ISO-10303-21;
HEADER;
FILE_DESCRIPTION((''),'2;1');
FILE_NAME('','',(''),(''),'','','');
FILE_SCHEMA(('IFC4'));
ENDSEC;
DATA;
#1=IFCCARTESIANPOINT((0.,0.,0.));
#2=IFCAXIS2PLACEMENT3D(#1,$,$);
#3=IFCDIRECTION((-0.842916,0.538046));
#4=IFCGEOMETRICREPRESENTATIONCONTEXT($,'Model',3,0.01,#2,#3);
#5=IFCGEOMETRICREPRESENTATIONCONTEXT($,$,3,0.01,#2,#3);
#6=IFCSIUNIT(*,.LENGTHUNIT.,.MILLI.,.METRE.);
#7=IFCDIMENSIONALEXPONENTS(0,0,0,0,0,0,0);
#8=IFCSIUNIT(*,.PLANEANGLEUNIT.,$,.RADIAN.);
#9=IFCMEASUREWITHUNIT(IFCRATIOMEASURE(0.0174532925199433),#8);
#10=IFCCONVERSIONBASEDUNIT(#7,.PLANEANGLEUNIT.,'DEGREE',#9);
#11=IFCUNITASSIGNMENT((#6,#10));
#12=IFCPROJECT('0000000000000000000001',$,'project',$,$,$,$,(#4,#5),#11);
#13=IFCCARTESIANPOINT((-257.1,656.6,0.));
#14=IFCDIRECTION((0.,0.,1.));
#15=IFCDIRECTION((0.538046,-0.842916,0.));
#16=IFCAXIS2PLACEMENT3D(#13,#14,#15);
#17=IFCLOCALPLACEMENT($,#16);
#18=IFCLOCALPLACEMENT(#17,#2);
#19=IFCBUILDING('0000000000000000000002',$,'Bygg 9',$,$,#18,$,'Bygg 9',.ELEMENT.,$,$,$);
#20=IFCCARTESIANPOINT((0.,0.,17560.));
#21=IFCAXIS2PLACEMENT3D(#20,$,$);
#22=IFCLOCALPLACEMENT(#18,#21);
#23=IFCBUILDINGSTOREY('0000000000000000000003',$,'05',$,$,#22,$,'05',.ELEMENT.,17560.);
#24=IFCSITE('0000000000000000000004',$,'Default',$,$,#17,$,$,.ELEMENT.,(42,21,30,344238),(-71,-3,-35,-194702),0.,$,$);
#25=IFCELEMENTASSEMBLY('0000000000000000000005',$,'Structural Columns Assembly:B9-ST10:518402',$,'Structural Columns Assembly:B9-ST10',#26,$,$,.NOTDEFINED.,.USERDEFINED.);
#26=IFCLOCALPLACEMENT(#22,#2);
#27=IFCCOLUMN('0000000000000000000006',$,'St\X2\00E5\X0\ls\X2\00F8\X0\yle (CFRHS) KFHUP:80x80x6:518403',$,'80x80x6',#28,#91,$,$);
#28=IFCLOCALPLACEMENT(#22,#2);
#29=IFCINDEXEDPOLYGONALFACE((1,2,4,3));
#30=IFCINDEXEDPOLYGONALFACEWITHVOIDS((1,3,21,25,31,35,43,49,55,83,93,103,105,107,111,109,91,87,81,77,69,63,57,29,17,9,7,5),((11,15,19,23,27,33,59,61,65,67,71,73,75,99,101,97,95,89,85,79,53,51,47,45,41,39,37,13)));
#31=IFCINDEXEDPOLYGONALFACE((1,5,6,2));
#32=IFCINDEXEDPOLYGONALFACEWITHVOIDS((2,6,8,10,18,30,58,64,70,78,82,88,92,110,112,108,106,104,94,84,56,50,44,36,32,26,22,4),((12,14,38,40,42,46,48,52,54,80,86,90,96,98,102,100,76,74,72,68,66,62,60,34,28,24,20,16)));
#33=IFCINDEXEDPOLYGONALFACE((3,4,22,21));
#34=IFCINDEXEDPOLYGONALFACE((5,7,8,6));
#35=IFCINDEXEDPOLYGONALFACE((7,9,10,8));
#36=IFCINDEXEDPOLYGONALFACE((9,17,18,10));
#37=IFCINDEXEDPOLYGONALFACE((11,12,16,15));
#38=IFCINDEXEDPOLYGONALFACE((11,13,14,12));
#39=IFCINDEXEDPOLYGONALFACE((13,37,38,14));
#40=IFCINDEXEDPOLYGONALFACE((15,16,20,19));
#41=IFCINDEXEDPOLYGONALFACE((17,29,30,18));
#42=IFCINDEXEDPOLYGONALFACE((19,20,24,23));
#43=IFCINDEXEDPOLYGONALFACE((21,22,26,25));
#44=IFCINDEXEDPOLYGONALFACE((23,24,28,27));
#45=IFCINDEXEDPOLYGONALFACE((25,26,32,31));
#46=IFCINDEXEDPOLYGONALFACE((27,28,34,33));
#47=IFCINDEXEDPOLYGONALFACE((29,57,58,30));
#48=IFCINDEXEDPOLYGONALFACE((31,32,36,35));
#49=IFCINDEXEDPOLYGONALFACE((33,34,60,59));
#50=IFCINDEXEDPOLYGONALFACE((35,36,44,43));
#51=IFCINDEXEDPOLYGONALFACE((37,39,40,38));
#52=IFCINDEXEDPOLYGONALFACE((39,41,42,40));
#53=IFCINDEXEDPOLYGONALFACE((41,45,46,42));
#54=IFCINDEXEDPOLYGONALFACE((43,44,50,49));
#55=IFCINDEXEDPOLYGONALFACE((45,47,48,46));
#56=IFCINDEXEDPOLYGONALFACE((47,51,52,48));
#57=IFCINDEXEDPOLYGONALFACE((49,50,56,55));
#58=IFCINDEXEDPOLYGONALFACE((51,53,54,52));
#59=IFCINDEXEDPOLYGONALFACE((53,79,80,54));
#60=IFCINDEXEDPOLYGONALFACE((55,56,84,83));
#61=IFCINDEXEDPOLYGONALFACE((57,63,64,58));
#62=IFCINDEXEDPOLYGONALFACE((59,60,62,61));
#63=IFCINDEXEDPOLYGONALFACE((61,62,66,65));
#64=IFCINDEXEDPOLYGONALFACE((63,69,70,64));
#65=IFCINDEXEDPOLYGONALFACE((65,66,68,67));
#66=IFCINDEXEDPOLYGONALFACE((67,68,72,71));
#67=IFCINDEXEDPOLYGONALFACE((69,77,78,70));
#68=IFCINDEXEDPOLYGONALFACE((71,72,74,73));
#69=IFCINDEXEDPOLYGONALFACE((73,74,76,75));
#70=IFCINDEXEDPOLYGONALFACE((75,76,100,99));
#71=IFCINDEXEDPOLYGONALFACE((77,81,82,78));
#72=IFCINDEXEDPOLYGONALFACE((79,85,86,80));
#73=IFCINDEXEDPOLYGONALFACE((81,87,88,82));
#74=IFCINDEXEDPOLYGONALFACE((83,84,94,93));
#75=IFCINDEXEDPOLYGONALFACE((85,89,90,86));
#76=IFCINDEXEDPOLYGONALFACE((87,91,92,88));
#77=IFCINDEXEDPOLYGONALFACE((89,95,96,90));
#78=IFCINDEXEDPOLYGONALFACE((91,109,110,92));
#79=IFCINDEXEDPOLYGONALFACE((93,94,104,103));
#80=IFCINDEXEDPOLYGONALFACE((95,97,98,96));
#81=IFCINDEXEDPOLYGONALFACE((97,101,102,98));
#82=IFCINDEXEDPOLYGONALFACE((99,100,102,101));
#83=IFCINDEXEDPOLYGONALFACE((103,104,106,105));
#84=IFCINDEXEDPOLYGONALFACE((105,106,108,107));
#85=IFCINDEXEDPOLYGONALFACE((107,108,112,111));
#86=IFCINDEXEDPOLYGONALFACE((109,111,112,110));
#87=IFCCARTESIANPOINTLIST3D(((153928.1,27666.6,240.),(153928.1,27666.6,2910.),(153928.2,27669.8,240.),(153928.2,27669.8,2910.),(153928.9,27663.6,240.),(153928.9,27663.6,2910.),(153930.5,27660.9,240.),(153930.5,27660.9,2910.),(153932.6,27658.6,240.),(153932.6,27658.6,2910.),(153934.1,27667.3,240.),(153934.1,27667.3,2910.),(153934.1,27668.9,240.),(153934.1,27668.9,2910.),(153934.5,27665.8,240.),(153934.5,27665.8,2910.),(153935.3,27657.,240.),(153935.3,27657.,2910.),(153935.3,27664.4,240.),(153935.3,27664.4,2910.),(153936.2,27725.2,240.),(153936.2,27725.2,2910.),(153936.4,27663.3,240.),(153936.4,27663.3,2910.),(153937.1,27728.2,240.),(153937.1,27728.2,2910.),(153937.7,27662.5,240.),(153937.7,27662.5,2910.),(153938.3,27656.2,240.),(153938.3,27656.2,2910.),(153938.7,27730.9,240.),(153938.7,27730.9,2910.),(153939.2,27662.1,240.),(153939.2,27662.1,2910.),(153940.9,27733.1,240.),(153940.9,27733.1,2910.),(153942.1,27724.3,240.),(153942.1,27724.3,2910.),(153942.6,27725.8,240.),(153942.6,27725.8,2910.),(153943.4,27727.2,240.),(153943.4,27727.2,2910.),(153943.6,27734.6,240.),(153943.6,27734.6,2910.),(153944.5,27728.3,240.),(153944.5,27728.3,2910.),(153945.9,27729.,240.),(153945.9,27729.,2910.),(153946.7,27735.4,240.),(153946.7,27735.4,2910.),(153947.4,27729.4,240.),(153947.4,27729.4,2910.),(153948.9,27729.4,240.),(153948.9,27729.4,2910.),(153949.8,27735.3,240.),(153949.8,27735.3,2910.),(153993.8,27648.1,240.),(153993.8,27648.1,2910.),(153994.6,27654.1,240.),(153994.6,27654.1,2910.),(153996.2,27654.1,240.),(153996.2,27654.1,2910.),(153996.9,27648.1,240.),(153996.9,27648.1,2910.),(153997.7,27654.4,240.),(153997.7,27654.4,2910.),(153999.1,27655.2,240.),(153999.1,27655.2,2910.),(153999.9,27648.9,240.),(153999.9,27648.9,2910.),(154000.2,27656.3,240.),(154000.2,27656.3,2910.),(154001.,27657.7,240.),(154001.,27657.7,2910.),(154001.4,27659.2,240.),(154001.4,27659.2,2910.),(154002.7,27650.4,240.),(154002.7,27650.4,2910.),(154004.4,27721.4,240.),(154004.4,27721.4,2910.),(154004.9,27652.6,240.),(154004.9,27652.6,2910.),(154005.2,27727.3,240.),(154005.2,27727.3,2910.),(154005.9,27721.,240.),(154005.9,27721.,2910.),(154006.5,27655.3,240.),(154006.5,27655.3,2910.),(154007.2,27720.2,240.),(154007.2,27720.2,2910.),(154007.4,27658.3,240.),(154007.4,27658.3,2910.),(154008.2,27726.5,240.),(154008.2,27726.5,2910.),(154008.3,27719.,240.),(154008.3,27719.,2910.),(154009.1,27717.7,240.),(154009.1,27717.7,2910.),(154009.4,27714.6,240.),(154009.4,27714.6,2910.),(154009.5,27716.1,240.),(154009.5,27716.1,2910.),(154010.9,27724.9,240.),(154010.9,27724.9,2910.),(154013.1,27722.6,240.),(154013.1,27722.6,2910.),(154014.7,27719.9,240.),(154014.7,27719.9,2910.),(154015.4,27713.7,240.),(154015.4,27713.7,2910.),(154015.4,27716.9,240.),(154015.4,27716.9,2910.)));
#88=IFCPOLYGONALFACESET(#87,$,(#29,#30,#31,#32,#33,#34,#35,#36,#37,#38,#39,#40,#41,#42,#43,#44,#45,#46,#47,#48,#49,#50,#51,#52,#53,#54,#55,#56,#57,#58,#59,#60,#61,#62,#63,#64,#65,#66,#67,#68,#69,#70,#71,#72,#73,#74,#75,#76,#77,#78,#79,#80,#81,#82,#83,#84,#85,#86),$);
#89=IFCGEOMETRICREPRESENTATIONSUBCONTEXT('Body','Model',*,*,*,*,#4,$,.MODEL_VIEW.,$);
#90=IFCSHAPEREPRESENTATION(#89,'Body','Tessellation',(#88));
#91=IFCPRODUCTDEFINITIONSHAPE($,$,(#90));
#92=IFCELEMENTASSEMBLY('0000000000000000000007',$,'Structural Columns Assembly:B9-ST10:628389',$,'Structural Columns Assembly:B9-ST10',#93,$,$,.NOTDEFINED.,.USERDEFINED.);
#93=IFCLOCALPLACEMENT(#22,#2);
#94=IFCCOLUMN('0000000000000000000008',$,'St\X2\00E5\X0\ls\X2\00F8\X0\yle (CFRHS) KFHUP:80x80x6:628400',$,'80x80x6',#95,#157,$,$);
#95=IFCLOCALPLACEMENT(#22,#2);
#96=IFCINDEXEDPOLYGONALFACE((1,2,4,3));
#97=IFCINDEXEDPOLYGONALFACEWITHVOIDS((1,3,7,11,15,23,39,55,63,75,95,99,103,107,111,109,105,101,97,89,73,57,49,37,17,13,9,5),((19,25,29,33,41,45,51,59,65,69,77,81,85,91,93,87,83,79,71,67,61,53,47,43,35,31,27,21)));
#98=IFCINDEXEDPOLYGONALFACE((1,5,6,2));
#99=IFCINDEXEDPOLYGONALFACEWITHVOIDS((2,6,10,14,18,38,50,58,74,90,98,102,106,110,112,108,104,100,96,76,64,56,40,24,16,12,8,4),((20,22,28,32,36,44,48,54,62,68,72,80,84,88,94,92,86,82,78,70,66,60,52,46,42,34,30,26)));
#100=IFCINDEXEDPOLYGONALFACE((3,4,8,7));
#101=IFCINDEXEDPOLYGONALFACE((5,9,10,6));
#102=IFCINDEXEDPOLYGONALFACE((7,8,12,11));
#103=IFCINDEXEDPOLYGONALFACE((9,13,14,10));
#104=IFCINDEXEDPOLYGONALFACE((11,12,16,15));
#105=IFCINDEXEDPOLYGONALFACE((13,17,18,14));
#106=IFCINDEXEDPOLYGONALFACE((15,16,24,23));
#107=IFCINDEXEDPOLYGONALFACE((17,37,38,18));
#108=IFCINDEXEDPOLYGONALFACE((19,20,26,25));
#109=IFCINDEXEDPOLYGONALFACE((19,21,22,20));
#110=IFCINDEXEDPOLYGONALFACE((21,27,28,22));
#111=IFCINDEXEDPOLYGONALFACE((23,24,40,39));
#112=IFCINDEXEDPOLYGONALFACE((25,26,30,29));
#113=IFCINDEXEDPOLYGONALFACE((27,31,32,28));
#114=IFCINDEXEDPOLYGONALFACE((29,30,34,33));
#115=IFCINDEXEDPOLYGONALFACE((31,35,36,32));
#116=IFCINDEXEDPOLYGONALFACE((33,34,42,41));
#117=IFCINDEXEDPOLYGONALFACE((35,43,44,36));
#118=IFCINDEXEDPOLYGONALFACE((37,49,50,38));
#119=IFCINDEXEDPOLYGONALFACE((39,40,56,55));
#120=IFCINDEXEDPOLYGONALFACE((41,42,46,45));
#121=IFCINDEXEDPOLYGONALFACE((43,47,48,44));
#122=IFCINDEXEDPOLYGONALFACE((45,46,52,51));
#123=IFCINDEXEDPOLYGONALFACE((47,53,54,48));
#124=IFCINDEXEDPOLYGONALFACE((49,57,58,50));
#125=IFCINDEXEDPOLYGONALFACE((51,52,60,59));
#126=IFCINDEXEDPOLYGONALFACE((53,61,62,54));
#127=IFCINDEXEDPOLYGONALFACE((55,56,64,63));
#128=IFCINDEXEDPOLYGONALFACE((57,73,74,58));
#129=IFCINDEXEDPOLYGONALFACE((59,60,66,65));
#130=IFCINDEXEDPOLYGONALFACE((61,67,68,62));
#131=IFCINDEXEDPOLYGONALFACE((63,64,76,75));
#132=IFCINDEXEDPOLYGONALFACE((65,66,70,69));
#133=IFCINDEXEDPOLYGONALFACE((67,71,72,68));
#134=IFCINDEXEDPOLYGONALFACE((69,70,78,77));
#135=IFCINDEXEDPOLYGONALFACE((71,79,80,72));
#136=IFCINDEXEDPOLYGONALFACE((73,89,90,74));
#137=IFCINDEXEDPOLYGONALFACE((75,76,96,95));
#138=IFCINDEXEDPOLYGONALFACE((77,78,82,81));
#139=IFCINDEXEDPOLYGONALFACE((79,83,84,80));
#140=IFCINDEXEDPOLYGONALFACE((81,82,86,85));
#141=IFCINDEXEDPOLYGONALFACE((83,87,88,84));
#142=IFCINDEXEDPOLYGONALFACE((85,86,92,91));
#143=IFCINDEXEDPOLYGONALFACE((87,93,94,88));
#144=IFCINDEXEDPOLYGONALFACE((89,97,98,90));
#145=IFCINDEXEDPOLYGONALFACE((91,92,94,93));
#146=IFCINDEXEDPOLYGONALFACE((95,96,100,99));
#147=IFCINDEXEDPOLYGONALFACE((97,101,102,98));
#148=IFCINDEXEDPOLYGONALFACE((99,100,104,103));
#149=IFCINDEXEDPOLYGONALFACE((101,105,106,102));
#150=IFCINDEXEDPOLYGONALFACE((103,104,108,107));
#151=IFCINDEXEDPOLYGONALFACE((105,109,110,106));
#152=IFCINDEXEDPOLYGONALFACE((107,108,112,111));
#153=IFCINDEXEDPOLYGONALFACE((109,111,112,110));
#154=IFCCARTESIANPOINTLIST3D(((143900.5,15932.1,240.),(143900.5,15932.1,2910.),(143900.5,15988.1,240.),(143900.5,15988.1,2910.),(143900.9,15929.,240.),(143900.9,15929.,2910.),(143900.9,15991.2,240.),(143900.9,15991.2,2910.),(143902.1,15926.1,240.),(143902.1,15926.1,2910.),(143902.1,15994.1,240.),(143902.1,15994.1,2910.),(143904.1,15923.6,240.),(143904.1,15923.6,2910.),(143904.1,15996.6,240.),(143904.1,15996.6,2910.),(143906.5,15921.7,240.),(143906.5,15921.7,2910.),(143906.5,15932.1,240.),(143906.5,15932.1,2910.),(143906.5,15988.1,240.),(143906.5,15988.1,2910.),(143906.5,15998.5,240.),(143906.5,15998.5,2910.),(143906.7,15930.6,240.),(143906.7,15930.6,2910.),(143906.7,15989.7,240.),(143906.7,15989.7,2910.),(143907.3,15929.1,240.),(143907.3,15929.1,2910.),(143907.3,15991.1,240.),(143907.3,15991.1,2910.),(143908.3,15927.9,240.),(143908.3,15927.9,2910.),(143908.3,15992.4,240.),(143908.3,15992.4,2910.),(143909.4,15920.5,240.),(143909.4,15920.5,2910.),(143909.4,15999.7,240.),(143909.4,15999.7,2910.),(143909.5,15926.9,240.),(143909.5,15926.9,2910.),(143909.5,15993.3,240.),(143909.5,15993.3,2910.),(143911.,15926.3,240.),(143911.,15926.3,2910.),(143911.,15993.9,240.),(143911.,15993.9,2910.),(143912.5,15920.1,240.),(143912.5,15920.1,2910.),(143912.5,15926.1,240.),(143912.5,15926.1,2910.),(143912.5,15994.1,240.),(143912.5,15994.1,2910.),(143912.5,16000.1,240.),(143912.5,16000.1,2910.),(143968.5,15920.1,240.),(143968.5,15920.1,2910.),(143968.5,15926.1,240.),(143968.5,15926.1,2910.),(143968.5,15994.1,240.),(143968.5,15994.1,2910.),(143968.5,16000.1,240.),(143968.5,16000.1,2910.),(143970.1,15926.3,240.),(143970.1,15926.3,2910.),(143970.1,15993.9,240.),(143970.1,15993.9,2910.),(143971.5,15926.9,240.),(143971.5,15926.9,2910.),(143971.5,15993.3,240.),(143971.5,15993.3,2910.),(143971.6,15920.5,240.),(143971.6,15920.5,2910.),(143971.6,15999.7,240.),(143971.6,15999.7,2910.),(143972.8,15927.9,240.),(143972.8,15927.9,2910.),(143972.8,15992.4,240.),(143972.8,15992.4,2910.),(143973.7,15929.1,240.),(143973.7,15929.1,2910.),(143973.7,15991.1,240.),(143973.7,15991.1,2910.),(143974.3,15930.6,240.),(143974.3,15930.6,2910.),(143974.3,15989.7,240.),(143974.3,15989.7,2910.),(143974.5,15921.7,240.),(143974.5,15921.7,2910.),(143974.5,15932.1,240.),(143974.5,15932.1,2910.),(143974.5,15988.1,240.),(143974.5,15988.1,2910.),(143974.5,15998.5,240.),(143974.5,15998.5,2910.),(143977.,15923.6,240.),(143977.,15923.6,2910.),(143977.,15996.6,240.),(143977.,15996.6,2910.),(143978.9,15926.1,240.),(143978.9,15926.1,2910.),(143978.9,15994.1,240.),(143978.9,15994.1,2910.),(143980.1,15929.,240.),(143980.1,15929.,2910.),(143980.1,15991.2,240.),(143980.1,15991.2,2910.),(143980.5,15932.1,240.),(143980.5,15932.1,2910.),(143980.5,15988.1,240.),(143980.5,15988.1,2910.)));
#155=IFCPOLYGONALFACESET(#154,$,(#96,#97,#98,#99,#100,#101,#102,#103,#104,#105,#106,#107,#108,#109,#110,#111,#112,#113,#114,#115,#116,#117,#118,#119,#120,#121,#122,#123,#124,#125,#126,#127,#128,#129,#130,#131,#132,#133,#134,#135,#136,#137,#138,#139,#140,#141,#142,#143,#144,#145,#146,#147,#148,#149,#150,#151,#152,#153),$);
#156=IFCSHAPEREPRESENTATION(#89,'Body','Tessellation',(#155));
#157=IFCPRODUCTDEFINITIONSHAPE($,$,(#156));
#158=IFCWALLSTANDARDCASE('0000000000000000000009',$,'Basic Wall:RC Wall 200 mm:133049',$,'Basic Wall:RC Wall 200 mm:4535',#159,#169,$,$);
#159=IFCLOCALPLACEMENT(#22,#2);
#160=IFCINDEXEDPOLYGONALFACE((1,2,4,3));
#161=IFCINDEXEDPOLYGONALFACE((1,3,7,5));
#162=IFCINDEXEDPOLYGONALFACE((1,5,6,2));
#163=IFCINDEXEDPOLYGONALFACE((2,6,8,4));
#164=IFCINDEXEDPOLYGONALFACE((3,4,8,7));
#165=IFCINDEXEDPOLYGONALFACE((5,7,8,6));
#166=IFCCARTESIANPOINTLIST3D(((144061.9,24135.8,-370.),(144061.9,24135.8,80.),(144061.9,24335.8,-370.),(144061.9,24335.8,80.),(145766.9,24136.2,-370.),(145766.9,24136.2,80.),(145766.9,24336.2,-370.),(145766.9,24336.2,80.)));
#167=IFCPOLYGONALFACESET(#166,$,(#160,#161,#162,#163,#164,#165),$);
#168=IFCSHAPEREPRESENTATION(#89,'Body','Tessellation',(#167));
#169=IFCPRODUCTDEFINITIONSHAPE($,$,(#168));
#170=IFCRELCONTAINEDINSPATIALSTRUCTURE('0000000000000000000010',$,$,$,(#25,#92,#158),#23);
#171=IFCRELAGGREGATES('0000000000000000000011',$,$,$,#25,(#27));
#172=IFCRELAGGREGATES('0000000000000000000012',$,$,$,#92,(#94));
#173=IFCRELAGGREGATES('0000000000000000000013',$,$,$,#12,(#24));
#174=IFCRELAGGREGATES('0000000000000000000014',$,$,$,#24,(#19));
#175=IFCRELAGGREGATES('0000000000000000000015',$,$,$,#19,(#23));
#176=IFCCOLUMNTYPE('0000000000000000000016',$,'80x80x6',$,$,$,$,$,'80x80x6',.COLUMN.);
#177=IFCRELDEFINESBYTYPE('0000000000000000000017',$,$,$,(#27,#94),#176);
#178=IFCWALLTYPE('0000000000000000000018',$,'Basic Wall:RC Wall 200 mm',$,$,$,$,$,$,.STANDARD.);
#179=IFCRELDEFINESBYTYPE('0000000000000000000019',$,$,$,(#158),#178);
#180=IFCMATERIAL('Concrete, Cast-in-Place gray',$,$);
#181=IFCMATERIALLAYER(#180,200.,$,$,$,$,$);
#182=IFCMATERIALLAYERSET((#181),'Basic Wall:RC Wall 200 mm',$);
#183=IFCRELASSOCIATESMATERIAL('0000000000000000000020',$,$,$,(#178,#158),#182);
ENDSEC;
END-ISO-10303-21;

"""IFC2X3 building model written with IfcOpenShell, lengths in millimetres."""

from ifc_helpers import new_model, entity, si_unit, converted_unit, direction, frame, frame_2d, origin, place, context, subcontext, project, spatial, polyline, circle_curve, parameter, trimmed, segment, composite_curve, outline, extrude, source, transform, mapped, material, layer, layer_set, layer_usage, type_object, type_shapes, element, aggregate, save


model = new_model("IFC2X3")

# Units and contexts
model_context = context("Model", 3, precision=0.01, world=origin(), true_north=direction((-0.842916, 0.538046)))
context_of_model = context(None, 3, precision=0.01, world=origin(), true_north=direction((-0.842916, 0.538046)))
body_context = subcontext(model_context, "Body", "Model", "MODEL_VIEW")
ifc_project = project(units=[si_unit("LENGTHUNIT", "METRE", prefix="MILLI"), converted_unit("PLANEANGLEUNIT", "DEGREE", entity("IfcRatioMeasure", 0.0174532925199433), si_unit("PLANEANGLEUNIT", "RADIAN"), dimensions=[0, 0, 0, 0, 0, 0, 0])], contexts=[model_context, context_of_model])

# Site, building, storey
site_placement = place(None, frame((-257.1, 656.6, 0.0), z_axis=(0.0, 0.0, 1.0), x_axis=(0.538046, -0.842916, 0.0)))
site = spatial("IfcSite", under=ifc_project, at=site_placement, Name="Default", CompositionType="ELEMENT", RefLatitude=(42, 21, 30, 344238), RefLongitude=(-71, -3, -35, -194702), RefElevation=0.0)
building_placement = place(site_placement, origin())
building = spatial("IfcBuilding", under=site, at=building_placement, Name="Bygg 9", LongName="Bygg 9", CompositionType="ELEMENT")
storey_placement = place(building_placement, frame((0.0, 0.0, 17560.0)))
storey = spatial("IfcBuildingStorey", under=building, at=storey_placement, Name="05", LongName="05", CompositionType="ELEMENT", Elevation=17560.0)

# Element assemblies, columns
column_type = type_object("IfcColumnType", Name="80x80x6", ElementType="80x80x6", PredefinedType="COLUMN")
shared_shape_1 = source(origin(), body_context, "Body", "SweptSolid", [
    extrude(outline(composite_curve([segment(trimmed(circle_curve(frame_2d((-28.0, 28.0), x_axis=(1.0, 0.0)), 12.0), [parameter(90.0)], [parameter(180.0)], True, "PARAMETER"), True, "CONTINUOUS"), segment(polyline([(-40.0, 28.0), (-40.0, -28.0)]), True, "CONTINUOUS"), segment(trimmed(circle_curve(frame_2d((-28.0, -28.0), x_axis=(1.0, 0.0)), 12.0), [parameter(180.0)], [parameter(270.0)], True, "PARAMETER"), True, "CONTINUOUS"), segment(polyline([(-28.0, -40.0), (28.0, -40.0)]), True, "CONTINUOUS"), segment(trimmed(circle_curve(frame_2d((28.0, -28.0), x_axis=(1.0, 0.0)), 12.0), [parameter(270.0)], [parameter(0.0)], True, "PARAMETER"), True, "CONTINUOUS"), segment(polyline([(40.0, -28.0), (40.0, 28.0)]), True, "CONTINUOUS"), segment(trimmed(circle_curve(frame_2d((28.0, 28.0), x_axis=(1.0, 0.0)), 12.0), [parameter(0.0)], [parameter(90.0)], True, "PARAMETER"), True, "CONTINUOUS"), segment(polyline([(28.0, 40.0), (-28.0, 40.0)]), True, "CONTINUOUS")], self_intersect=False), holes=[composite_curve([segment(polyline([(-28.0, 34.0), (28.0, 34.0)]), True, "CONTINUOUS"), segment(trimmed(circle_curve(frame_2d((28.0, 28.0), x_axis=(1.0, 0.0)), 6.0), [parameter(360.0)], [parameter(90.0)], True, "PARAMETER"), False, "CONTINUOUS"), segment(polyline([(34.0, 28.0), (34.0, -28.0)]), True, "CONTINUOUS"), segment(trimmed(circle_curve(frame_2d((28.0, -28.0), x_axis=(1.0, 0.0)), 6.0), [parameter(270.0)], [parameter(360.0)], True, "PARAMETER"), False, "CONTINUOUS"), segment(polyline([(28.0, -34.0), (-28.0, -34.0)]), True, "CONTINUOUS"), segment(trimmed(circle_curve(frame_2d((-28.0, -28.0), x_axis=(1.0, 0.0)), 6.0), [parameter(180.0)], [parameter(270.0)], True, "PARAMETER"), False, "CONTINUOUS"), segment(polyline([(-34.0, -28.0), (-34.0, 28.0)]), True, "CONTINUOUS"), segment(trimmed(circle_curve(frame_2d((-28.0, 28.0), x_axis=(1.0, 0.0)), 6.0), [parameter(90.0)], [parameter(180.0)], True, "PARAMETER"), False, "CONTINUOUS")], self_intersect=False)]), frame((41.6, 41.6, 0.0), z_axis=(0.0, 0.0, 1.0), x_axis=(-1.0, 0.0, 0.0)), (0.0, 0.0, 1.0), 2670.0),
])
type_shapes(column_type, [shared_shape_1])
assembly_1_placement = place(storey_placement, origin())
assembly_1 = element("IfcElementAssembly", 1, at=assembly_1_placement, inside=storey, Name="Structural Columns Assembly:B9-ST10:518402", ObjectType="Structural Columns Assembly:B9-ST10", AssemblyPlace="NOTDEFINED", PredefinedType="USERDEFINED")
column_1_placement = place(assembly_1_placement, frame((154018.9, 27726.9, 240.0), z_axis=(0.0, 0.0, 1.0), x_axis=(-0.989691, 0.143216, 0.0)))
column_1 = element("IfcColumn", 2, at=column_1_placement, type_object=column_type, Name="Stålsøyle (CFRHS) KFHUP:80x80x6:518403", ObjectType="80x80x6", context=body_context, shape_type="MappedRepresentation", body=[
    mapped(shared_shape_1, transform((0.0, 0.0, 0.0), scale=1.0)),
])
assembly_2_placement = place(storey_placement, origin())
assembly_2 = element("IfcElementAssembly", 3, at=assembly_2_placement, inside=storey, Name="Structural Columns Assembly:B9-ST10:628389", ObjectType="Structural Columns Assembly:B9-ST10", AssemblyPlace="NOTDEFINED", PredefinedType="USERDEFINED")
column_2_placement = place(assembly_2_placement, frame((143982.1, 15918.5, 240.0), z_axis=(0.0, 0.0, 1.0), x_axis=(0.0, 1.0, 0.0)))
column_2 = element("IfcColumn", 4, at=column_2_placement, type_object=column_type, Name="Stålsøyle (CFRHS) KFHUP:80x80x6:628400", ObjectType="80x80x6", context=body_context, shape_type="MappedRepresentation", body=[
    mapped(shared_shape_1, transform((0.0, 0.0, 0.0), scale=1.0)),
])

# Shared definitions
ifc_material_1 = material(Name="Concrete, Cast-in-Place gray")

# Wall
ifc_layer_1 = layer(ifc_material_1, 200.0)
ifc_layer_set_1 = layer_set([ifc_layer_1], Name="Basic Wall:RC Wall 200 mm")
ifc_layer_usage_1 = layer_usage(ifc_layer_set_1, "AXIS2", "NEGATIVE", 100.0)
wall_type = type_object("IfcWallType", Name="Basic Wall:RC Wall 200 mm", PredefinedType="STANDARD", material=ifc_layer_set_1)
wall_placement = place(storey_placement, frame((144061.9, 24235.8, -370.0), z_axis=(0.0, 0.0, 1.0), x_axis=(1.0, 0.000201, 0.0)))
element("IfcWallStandardCase", 5, at=wall_placement, inside=storey, type_object=wall_type, material=ifc_layer_usage_1, Name="Basic Wall:RC Wall 200 mm:133049", ObjectType="Basic Wall:RC Wall 200 mm:4535", context=body_context, shape_type="SweptSolid", body=[
    extrude(outline(polyline([(1705.0, -100.0), (1705.0, 100.0), (0.0, 100.0), (0.0, -100.0), (1705.0, -100.0)])), origin(), (0.0, 0.0, 1.0), 450.0),
])

aggregate(assembly_1, [column_1])
aggregate(assembly_2, [column_2])

save(model, "model.ifc")
